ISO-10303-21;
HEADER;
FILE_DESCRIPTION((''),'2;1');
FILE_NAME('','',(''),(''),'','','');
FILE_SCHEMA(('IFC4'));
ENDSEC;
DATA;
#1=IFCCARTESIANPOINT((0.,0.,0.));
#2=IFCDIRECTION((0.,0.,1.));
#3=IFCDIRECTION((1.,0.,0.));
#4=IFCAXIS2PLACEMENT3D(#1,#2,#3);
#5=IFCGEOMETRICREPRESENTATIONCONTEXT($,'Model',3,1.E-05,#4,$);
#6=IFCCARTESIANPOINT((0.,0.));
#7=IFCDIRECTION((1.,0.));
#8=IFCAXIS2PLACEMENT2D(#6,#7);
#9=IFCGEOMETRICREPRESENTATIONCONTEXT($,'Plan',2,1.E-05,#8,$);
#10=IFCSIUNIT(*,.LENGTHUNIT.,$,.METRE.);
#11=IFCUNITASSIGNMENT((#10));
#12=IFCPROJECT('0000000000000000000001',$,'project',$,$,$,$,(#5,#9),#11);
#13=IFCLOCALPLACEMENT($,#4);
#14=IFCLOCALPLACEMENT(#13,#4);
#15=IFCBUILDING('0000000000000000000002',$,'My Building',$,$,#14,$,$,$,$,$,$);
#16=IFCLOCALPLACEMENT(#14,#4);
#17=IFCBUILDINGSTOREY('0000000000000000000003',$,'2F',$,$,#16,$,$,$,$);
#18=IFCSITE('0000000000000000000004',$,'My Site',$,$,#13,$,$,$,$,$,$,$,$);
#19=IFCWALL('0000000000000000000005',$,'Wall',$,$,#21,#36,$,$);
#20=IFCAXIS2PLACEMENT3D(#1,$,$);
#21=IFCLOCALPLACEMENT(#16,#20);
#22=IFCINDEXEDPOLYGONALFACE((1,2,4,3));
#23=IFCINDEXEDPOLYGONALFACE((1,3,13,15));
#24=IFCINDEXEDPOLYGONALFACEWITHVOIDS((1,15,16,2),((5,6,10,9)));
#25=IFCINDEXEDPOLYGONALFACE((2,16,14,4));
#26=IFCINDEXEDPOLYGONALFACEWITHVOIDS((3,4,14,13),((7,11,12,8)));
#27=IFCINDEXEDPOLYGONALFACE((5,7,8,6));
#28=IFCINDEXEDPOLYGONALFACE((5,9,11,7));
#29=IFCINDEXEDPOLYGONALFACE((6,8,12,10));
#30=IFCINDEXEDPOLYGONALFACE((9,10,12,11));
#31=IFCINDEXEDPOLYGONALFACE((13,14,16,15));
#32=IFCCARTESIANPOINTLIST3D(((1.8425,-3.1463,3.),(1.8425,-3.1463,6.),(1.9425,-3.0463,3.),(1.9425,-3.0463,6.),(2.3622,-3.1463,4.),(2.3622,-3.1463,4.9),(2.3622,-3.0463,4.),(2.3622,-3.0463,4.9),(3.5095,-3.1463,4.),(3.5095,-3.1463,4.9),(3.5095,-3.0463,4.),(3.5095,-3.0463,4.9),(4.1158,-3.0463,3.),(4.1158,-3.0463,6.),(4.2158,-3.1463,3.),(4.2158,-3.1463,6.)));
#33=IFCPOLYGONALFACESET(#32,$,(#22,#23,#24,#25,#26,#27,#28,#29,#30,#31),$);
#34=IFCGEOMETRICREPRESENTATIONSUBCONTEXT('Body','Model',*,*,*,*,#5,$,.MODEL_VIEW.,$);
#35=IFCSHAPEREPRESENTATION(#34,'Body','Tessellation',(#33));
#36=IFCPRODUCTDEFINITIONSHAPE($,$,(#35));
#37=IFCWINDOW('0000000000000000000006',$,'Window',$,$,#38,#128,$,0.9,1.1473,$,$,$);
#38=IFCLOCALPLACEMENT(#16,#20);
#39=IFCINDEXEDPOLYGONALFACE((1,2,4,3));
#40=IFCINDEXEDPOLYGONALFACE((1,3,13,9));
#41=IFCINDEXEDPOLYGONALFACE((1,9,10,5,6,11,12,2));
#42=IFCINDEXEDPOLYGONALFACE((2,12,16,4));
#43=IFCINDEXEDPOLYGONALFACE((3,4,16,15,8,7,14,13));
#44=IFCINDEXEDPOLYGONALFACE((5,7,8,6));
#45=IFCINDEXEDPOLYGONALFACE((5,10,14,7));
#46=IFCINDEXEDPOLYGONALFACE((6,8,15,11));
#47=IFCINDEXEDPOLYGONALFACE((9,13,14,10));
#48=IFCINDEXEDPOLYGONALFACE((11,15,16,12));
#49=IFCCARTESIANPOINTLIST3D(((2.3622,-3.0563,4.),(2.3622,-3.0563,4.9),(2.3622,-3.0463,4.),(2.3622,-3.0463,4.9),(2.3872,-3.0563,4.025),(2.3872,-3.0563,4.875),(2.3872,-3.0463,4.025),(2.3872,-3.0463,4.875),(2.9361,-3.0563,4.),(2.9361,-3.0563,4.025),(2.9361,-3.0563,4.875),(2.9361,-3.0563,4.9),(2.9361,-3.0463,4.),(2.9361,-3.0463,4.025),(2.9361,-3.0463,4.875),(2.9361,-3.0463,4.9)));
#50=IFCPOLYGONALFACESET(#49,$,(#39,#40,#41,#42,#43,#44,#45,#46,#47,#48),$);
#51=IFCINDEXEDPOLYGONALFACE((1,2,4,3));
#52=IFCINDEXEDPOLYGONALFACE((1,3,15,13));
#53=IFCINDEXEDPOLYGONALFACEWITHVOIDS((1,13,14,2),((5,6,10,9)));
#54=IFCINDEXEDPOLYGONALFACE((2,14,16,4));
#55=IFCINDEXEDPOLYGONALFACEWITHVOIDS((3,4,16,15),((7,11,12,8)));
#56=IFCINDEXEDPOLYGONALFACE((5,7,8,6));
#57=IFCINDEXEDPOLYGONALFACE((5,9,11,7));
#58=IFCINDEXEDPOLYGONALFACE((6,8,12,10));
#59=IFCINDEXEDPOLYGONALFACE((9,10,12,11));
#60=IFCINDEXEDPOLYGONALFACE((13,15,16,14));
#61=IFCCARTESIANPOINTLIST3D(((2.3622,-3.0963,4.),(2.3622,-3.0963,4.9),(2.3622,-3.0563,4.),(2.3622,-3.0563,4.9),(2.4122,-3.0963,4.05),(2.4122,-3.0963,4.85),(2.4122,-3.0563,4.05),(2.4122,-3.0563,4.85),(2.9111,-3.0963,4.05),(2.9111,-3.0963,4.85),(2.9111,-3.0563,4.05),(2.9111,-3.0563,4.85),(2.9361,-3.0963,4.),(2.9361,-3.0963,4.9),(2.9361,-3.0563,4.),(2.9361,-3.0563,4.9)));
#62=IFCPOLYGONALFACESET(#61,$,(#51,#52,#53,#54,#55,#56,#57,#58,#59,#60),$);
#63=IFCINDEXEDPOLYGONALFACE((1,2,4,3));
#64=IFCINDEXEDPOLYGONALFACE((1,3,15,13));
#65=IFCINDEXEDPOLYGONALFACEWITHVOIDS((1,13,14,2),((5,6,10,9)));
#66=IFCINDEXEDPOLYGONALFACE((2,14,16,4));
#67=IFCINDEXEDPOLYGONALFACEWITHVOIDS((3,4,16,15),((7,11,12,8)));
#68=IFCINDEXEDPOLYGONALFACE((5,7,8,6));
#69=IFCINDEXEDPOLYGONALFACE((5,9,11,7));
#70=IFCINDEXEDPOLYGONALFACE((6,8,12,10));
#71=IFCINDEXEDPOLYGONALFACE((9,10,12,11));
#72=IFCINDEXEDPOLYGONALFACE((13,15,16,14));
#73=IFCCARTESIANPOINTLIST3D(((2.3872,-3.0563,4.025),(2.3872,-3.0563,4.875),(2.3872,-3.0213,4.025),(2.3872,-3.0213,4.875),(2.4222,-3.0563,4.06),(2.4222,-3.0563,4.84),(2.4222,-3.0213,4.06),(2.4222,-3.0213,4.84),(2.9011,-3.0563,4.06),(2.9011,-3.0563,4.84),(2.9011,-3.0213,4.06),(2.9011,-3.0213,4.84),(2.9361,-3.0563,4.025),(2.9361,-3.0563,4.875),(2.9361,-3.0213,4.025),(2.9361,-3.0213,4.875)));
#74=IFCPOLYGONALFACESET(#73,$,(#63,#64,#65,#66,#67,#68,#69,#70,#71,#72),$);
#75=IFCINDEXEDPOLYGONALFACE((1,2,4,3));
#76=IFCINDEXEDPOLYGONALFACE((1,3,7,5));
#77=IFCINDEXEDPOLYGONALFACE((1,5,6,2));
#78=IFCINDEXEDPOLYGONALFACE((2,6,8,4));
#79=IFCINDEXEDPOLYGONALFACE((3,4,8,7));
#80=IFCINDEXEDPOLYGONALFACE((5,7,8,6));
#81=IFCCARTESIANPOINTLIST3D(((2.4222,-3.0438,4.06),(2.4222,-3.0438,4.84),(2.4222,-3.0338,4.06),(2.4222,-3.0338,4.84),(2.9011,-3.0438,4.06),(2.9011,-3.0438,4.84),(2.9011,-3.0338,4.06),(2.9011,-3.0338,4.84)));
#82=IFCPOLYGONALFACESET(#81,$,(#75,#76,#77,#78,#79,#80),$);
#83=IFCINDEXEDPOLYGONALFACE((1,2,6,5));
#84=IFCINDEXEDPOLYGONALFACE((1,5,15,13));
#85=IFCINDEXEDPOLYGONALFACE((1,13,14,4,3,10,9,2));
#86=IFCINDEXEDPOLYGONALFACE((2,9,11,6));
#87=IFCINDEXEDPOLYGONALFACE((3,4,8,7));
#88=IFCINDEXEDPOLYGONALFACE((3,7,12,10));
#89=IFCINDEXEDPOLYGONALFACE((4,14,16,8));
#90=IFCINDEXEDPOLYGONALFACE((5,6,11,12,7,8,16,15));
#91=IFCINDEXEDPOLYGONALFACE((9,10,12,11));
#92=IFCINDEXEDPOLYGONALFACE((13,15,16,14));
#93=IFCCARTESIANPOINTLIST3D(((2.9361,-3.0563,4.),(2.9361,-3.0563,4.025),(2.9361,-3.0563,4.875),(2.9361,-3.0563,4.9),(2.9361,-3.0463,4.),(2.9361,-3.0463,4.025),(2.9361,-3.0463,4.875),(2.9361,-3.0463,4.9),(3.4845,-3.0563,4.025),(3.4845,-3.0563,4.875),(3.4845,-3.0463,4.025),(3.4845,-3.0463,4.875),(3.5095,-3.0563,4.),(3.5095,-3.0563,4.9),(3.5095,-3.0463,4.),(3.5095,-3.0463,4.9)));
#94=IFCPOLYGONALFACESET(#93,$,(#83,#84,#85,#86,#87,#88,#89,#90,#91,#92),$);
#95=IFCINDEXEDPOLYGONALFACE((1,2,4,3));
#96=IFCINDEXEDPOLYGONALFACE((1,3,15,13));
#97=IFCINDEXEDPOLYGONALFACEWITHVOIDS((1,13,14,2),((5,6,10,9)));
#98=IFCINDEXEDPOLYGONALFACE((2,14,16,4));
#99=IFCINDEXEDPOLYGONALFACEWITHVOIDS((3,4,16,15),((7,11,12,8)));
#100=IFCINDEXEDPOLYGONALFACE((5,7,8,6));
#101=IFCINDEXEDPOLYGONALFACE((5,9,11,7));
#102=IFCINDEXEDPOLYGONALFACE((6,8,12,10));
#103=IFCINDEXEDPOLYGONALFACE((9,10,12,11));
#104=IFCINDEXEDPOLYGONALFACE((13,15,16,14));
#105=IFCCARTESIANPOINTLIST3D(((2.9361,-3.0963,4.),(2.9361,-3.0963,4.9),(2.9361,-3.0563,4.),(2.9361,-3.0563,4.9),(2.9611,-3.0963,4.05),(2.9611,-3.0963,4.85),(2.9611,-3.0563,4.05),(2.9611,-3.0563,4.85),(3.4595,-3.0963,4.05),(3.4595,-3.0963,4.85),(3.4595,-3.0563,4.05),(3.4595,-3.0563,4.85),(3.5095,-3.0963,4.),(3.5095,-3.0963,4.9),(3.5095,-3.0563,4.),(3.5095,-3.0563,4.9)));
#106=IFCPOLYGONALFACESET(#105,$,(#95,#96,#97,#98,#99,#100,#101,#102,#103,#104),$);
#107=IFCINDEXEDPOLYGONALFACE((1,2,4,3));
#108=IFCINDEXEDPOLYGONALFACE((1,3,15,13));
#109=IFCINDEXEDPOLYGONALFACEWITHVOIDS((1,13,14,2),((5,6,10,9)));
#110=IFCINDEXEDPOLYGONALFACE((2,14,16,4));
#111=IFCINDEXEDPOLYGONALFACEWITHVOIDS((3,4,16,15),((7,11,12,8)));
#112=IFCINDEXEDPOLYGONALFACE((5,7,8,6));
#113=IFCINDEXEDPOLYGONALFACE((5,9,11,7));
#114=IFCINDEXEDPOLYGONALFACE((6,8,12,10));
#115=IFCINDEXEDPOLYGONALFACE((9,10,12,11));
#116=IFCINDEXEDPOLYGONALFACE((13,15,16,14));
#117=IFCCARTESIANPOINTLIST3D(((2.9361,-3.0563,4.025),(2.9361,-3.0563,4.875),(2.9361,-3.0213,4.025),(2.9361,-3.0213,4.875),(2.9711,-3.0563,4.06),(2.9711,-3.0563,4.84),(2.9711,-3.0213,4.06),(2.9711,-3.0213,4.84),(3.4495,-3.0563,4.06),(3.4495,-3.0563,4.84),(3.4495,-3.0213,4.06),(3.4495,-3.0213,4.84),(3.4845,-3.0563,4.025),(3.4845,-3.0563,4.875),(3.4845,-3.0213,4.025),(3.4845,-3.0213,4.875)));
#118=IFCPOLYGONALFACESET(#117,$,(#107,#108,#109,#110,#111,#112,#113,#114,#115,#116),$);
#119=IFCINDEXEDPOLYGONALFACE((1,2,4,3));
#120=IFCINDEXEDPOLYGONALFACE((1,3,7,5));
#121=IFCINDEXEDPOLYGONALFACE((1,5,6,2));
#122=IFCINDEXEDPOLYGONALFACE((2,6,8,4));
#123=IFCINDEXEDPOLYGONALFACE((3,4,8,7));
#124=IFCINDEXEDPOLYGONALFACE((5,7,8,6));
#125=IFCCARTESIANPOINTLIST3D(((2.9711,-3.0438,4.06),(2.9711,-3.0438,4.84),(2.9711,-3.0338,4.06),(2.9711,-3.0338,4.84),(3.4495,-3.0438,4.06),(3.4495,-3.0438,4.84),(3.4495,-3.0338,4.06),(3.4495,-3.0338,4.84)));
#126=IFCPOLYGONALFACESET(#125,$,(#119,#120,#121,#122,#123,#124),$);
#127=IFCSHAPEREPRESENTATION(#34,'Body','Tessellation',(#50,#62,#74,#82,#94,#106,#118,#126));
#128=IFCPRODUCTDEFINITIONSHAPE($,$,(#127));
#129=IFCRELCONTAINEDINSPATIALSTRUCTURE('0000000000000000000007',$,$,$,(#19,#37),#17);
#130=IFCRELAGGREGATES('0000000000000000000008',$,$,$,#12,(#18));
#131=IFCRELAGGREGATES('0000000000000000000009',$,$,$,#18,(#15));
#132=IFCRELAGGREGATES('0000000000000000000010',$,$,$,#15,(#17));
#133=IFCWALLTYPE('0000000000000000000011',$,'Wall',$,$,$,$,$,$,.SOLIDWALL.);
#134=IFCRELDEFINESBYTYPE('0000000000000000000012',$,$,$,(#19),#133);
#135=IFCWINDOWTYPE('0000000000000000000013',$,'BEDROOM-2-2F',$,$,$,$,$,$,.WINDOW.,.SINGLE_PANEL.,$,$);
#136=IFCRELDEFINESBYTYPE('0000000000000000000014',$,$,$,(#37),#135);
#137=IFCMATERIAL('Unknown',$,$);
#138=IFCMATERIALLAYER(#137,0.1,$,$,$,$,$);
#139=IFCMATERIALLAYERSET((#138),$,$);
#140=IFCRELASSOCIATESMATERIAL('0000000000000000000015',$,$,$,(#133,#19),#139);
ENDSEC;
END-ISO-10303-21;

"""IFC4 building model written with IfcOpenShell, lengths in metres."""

from ifc_helpers import new_model, entity, si_unit, frame, origin_with_axes, origin_2d_with_axis, place, context, subcontext, project, spatial, line, indexed_curve, outline, extrude, shape, source, transform, mapped, material, layer, layer_set, layer_usage, type_object, type_shapes, element, fill, save


model = new_model("IFC4")

# Units and contexts
model_context = context("Model", 3, precision=1e-05, world=origin_with_axes())
plan_context = context("Plan", 2, precision=1e-05, world=origin_2d_with_axis())
body_context_1 = subcontext(model_context, "Body", "Model", "MODEL_VIEW")
body_context_2 = subcontext(plan_context, "Body", "Plan", "PLAN_VIEW")
ifc_project = project(units=[si_unit("LENGTHUNIT", "METRE")], contexts=[model_context, plan_context])

# Site, building, storey
site_placement = place(None, origin_with_axes())
site = spatial("IfcSite", under=ifc_project, at=site_placement, Name="My Site")
building_placement = place(site_placement, origin_with_axes())
building = spatial("IfcBuilding", under=site, at=building_placement, Name="My Building")
storey_placement = place(building_placement, origin_with_axes())
storey = spatial("IfcBuildingStorey", under=building, at=storey_placement, Name="2F")

# Shared definitions
ifc_material = material(Name="Unknown")

# Shared definitions
ifc_layer_1 = layer(ifc_material, 0.1)
ifc_layer_set_1 = layer_set([ifc_layer_1])
wall_type = type_object("IfcWallType", Name="Wall", PredefinedType="SOLIDWALL", material=ifc_layer_set_1)

# Wall, opening, window
ifc_layer_usage_1 = layer_usage(ifc_layer_set_1, "AXIS2", "POSITIVE", 0.0)
wall_1_placement = place(storey_placement, frame((1.8425, -3.1463, 3.0), z_axis=(0.0, 0.0, 1.0), x_axis=(1.0, 0.0, 0.0)))
wall_1 = element("IfcWall", 1, at=wall_1_placement, inside=storey, type_object=wall_type, material=ifc_layer_usage_1, Name="Wall", context=body_context_1, shape_type="SweptSolid", body=[
    extrude(outline(indexed_curve([(0.0, 0.0), (0.1, 0.1), (2.2734, 0.1), (2.3734, 0.0)], segments=[line(1, 2, 3, 4, 1)])), origin_with_axes(), (0.0, 0.0, 1.0), 3.0),
])
shared_shape_1 = source(origin_with_axes(), body_context_1, "Body", "SweptSolid", [
    extrude(outline(indexed_curve([(0.0, 0.0), (1.1473, 0.0), (1.1473, 0.9), (0.0, 0.9)], segments=[line(1, 2, 3, 4, 1)])), frame((0.0, -0.6, 0.0), z_axis=(0.0, -1.0, 0.0), x_axis=(1.0, 0.0, 0.0)), (0.0, 0.0, -1.0), 1.2),
])
opening_1_placement = place(wall_1_placement, frame((0.5197, 0.0, 1.0), z_axis=(0.0, 0.0, 1.0), x_axis=(1.0, 0.0, 0.0)))
opening_1 = element("IfcOpeningElement", 2, at=opening_1_placement, cuts=wall_1, PredefinedType="OPENING", context=body_context_1, shape_type="MappedRepresentation", body=[
    mapped(shared_shape_1, transform((0.0, 0.0, 0.0), x_axis=(1.0, 0.0, 0.0), y_axis=(0.0, 1.0, 0.0), z_axis=(0.0, 0.0, 1.0), scale=1.0)),
])
window_type_1 = type_object("IfcWindowType", Name="BEDROOM-2-2F", PartitioningType="SINGLE_PANEL", PredefinedType="WINDOW")
shared_shape_2 = source(origin_with_axes(), body_context_1, "Body", "SweptSolid", [
    extrude(outline(indexed_curve([(0.5739, 0.0), (0.0, 0.0), (0.0, 0.9), (0.5739, 0.9), (0.5739, 0.875), (0.025, 0.875), (0.025, 0.025), (0.5739, 0.025)], segments=[line(1, 2, 3, 4, 5, 6, 7, 8, 1)])), frame((0.0, 0.09, 0.0), z_axis=(0.0, -1.0, 0.0), x_axis=(1.0, 0.0, 0.0)), (0.0, 0.0, -1.0), 0.01),
    extrude(outline(indexed_curve([(0.0, 0.0), (0.5739, 0.0), (0.5739, 0.9), (0.0, 0.9)], segments=[line(1, 2, 3, 4, 1)]), holes=[indexed_curve([(0.05, 0.05), (0.5489, 0.05), (0.5489, 0.85), (0.05, 0.85)], segments=[line(1, 2, 3, 4, 1)])]), frame((0.0, 0.05, 0.0), z_axis=(0.0, -1.0, 0.0), x_axis=(1.0, 0.0, 0.0)), (0.0, 0.0, -1.0), 0.04),
    extrude(outline(indexed_curve([(0.0, 0.0), (0.5489, 0.0), (0.5489, 0.85), (0.0, 0.85)], segments=[line(1, 2, 3, 4, 1)]), holes=[indexed_curve([(0.035, 0.035), (0.5139, 0.035), (0.5139, 0.815), (0.035, 0.815)], segments=[line(1, 2, 3, 4, 1)])]), frame((0.025, 0.09, 0.025), z_axis=(0.0, -1.0, 0.0), x_axis=(1.0, 0.0, 0.0)), (0.0, 0.0, -1.0), 0.035),
    extrude(outline(indexed_curve([(0.035, 0.035), (0.5139, 0.035), (0.5139, 0.815), (0.035, 0.815)], segments=[line(1, 2, 3, 4, 1)])), frame((0.025, 0.1025, 0.025), z_axis=(0.0, -1.0, 0.0), x_axis=(1.0, 0.0, 0.0)), (0.0, 0.0, -1.0), 0.01),
    extrude(outline(indexed_curve([(0.0, 0.9), (0.5733, 0.9), (0.5733, 0.0), (0.0, 0.0), (0.0, 0.025), (0.5483, 0.025), (0.5483, 0.875), (0.0, 0.875)], segments=[line(1, 2, 3, 4, 5, 6, 7, 8, 1)])), frame((0.5739, 0.09, 0.0), z_axis=(0.0, -1.0, 0.0), x_axis=(1.0, 0.0, 0.0)), (0.0, 0.0, -1.0), 0.01),
    extrude(outline(indexed_curve([(0.0, 0.0), (0.5733, 0.0), (0.5733, 0.9), (0.0, 0.9)], segments=[line(1, 2, 3, 4, 1)]), holes=[indexed_curve([(0.025, 0.05), (0.5233, 0.05), (0.5233, 0.85), (0.025, 0.85)], segments=[line(1, 2, 3, 4, 1)])]), frame((0.5739, 0.05, 0.0), z_axis=(0.0, -1.0, 0.0), x_axis=(1.0, 0.0, 0.0)), (0.0, 0.0, -1.0), 0.04),
    extrude(outline(indexed_curve([(0.0, 0.0), (0.5483, 0.0), (0.5483, 0.85), (0.0, 0.85)], segments=[line(1, 2, 3, 4, 1)]), holes=[indexed_curve([(0.035, 0.035), (0.5133, 0.035), (0.5133, 0.815), (0.035, 0.815)], segments=[line(1, 2, 3, 4, 1)])]), frame((0.5739, 0.09, 0.025), z_axis=(0.0, -1.0, 0.0), x_axis=(1.0, 0.0, 0.0)), (0.0, 0.0, -1.0), 0.035),
    extrude(outline(indexed_curve([(0.035, 0.035), (0.5133, 0.035), (0.5133, 0.815), (0.035, 0.815)], segments=[line(1, 2, 3, 4, 1)])), frame((0.5739, 0.1025, 0.025), z_axis=(0.0, -1.0, 0.0), x_axis=(1.0, 0.0, 0.0)), (0.0, 0.0, -1.0), 0.01),
])
shared_shape_3 = source(origin_with_axes(), body_context_2, "Body", "Curve2D", [
    entity("IfcIndexedPolyCurve", entity("IfcCartesianPointList2D", [[0.05, 0.05], [0.5489, 0.05]])),
    entity("IfcIndexedPolyCurve", entity("IfcCartesianPointList2D", [[0.0, 0.1], [0.025, 0.1], [0.025, 0.09], [0.05, 0.09], [0.05, 0.05], [0.0, 0.05]]), [entity("IfcLineIndex", [1, 2, 3, 4, 5, 6, 1])]),
    entity("IfcIndexedPolyCurve", entity("IfcCartesianPointList2D", [[0.5739, 0.1], [0.5739, 0.1], [0.5739, 0.09], [0.5489, 0.09], [0.5489, 0.05], [0.5739, 0.05]])),
    entity("IfcIndexedPolyCurve", entity("IfcCartesianPointList2D", [[0.025, 0.09], [0.06, 0.09], [0.06, 0.125], [0.025, 0.125]]), [entity("IfcLineIndex", [1, 2, 3, 4, 1])]),
    entity("IfcIndexedPolyCurve", entity("IfcCartesianPointList2D", [[0.5739, 0.09], [0.5389, 0.09], [0.5389, 0.125], [0.5739, 0.125]]), [entity("IfcLineIndex", [1, 2, 3, 4, 1])]),
    entity("IfcIndexedPolyCurve", entity("IfcCartesianPointList2D", [[0.06, 0.09], [0.5389, 0.09]])),
    entity("IfcIndexedPolyCurve", entity("IfcCartesianPointList2D", [[0.06, 0.125], [0.5389, 0.125]])),
    entity("IfcIndexedPolyCurve", entity("IfcCartesianPointList2D", [[0.06, 0.1075], [0.5389, 0.1075]])),
    entity("IfcIndexedPolyCurve", entity("IfcCartesianPointList2D", [[0.5989, 0.05], [1.0973, 0.05]])),
    entity("IfcIndexedPolyCurve", entity("IfcCartesianPointList2D", [[0.5739, 0.1], [0.5739, 0.1], [0.5739, 0.09], [0.5989, 0.09], [0.5989, 0.05], [0.5739, 0.05]])),
    entity("IfcIndexedPolyCurve", entity("IfcCartesianPointList2D", [[1.1473, 0.1], [1.1223, 0.1], [1.1223, 0.09], [1.0973, 0.09], [1.0973, 0.05], [1.1473, 0.05]]), [entity("IfcLineIndex", [1, 2, 3, 4, 5, 6, 1])]),
    entity("IfcIndexedPolyCurve", entity("IfcCartesianPointList2D", [[0.5739, 0.09], [0.6089, 0.09], [0.6089, 0.125], [0.5739, 0.125]]), [entity("IfcLineIndex", [1, 2, 3, 4, 1])]),
    entity("IfcIndexedPolyCurve", entity("IfcCartesianPointList2D", [[1.1223, 0.09], [1.0873, 0.09], [1.0873, 0.125], [1.1223, 0.125]]), [entity("IfcLineIndex", [1, 2, 3, 4, 1])]),
    entity("IfcIndexedPolyCurve", entity("IfcCartesianPointList2D", [[0.6089, 0.09], [1.0873, 0.09]])),
    entity("IfcIndexedPolyCurve", entity("IfcCartesianPointList2D", [[0.6089, 0.125], [1.0873, 0.125]])),
    entity("IfcIndexedPolyCurve", entity("IfcCartesianPointList2D", [[0.6089, 0.1075], [1.0873, 0.1075]])),
])
type_shapes(window_type_1, [shared_shape_2, shared_shape_3])
window_1_placement = place(opening_1_placement, origin_with_axes())
window_1 = element("IfcWindow", 3, at=window_1_placement, inside=storey, type_object=window_type_1, Name="Window", OverallHeight=0.9, OverallWidth=1.1473, shapes=[
    shape(body_context_1, "Body", "MappedRepresentation", [mapped(shared_shape_2, transform((0.0, 0.0, 0.0), x_axis=(1.0, 0.0, 0.0), y_axis=(0.0, 1.0, 0.0), z_axis=(0.0, 0.0, 1.0), scale=1.0))]),
    shape(body_context_2, "Body", "MappedRepresentation", [mapped(shared_shape_3, transform((0.0, 0.0, 0.0), x_axis=(1.0, 0.0, 0.0), y_axis=(0.0, 1.0, 0.0), z_axis=(0.0, 0.0, 1.0), scale=1.0))]),
])
fill(opening_1, window_1)

save(model, "model.ifc")
